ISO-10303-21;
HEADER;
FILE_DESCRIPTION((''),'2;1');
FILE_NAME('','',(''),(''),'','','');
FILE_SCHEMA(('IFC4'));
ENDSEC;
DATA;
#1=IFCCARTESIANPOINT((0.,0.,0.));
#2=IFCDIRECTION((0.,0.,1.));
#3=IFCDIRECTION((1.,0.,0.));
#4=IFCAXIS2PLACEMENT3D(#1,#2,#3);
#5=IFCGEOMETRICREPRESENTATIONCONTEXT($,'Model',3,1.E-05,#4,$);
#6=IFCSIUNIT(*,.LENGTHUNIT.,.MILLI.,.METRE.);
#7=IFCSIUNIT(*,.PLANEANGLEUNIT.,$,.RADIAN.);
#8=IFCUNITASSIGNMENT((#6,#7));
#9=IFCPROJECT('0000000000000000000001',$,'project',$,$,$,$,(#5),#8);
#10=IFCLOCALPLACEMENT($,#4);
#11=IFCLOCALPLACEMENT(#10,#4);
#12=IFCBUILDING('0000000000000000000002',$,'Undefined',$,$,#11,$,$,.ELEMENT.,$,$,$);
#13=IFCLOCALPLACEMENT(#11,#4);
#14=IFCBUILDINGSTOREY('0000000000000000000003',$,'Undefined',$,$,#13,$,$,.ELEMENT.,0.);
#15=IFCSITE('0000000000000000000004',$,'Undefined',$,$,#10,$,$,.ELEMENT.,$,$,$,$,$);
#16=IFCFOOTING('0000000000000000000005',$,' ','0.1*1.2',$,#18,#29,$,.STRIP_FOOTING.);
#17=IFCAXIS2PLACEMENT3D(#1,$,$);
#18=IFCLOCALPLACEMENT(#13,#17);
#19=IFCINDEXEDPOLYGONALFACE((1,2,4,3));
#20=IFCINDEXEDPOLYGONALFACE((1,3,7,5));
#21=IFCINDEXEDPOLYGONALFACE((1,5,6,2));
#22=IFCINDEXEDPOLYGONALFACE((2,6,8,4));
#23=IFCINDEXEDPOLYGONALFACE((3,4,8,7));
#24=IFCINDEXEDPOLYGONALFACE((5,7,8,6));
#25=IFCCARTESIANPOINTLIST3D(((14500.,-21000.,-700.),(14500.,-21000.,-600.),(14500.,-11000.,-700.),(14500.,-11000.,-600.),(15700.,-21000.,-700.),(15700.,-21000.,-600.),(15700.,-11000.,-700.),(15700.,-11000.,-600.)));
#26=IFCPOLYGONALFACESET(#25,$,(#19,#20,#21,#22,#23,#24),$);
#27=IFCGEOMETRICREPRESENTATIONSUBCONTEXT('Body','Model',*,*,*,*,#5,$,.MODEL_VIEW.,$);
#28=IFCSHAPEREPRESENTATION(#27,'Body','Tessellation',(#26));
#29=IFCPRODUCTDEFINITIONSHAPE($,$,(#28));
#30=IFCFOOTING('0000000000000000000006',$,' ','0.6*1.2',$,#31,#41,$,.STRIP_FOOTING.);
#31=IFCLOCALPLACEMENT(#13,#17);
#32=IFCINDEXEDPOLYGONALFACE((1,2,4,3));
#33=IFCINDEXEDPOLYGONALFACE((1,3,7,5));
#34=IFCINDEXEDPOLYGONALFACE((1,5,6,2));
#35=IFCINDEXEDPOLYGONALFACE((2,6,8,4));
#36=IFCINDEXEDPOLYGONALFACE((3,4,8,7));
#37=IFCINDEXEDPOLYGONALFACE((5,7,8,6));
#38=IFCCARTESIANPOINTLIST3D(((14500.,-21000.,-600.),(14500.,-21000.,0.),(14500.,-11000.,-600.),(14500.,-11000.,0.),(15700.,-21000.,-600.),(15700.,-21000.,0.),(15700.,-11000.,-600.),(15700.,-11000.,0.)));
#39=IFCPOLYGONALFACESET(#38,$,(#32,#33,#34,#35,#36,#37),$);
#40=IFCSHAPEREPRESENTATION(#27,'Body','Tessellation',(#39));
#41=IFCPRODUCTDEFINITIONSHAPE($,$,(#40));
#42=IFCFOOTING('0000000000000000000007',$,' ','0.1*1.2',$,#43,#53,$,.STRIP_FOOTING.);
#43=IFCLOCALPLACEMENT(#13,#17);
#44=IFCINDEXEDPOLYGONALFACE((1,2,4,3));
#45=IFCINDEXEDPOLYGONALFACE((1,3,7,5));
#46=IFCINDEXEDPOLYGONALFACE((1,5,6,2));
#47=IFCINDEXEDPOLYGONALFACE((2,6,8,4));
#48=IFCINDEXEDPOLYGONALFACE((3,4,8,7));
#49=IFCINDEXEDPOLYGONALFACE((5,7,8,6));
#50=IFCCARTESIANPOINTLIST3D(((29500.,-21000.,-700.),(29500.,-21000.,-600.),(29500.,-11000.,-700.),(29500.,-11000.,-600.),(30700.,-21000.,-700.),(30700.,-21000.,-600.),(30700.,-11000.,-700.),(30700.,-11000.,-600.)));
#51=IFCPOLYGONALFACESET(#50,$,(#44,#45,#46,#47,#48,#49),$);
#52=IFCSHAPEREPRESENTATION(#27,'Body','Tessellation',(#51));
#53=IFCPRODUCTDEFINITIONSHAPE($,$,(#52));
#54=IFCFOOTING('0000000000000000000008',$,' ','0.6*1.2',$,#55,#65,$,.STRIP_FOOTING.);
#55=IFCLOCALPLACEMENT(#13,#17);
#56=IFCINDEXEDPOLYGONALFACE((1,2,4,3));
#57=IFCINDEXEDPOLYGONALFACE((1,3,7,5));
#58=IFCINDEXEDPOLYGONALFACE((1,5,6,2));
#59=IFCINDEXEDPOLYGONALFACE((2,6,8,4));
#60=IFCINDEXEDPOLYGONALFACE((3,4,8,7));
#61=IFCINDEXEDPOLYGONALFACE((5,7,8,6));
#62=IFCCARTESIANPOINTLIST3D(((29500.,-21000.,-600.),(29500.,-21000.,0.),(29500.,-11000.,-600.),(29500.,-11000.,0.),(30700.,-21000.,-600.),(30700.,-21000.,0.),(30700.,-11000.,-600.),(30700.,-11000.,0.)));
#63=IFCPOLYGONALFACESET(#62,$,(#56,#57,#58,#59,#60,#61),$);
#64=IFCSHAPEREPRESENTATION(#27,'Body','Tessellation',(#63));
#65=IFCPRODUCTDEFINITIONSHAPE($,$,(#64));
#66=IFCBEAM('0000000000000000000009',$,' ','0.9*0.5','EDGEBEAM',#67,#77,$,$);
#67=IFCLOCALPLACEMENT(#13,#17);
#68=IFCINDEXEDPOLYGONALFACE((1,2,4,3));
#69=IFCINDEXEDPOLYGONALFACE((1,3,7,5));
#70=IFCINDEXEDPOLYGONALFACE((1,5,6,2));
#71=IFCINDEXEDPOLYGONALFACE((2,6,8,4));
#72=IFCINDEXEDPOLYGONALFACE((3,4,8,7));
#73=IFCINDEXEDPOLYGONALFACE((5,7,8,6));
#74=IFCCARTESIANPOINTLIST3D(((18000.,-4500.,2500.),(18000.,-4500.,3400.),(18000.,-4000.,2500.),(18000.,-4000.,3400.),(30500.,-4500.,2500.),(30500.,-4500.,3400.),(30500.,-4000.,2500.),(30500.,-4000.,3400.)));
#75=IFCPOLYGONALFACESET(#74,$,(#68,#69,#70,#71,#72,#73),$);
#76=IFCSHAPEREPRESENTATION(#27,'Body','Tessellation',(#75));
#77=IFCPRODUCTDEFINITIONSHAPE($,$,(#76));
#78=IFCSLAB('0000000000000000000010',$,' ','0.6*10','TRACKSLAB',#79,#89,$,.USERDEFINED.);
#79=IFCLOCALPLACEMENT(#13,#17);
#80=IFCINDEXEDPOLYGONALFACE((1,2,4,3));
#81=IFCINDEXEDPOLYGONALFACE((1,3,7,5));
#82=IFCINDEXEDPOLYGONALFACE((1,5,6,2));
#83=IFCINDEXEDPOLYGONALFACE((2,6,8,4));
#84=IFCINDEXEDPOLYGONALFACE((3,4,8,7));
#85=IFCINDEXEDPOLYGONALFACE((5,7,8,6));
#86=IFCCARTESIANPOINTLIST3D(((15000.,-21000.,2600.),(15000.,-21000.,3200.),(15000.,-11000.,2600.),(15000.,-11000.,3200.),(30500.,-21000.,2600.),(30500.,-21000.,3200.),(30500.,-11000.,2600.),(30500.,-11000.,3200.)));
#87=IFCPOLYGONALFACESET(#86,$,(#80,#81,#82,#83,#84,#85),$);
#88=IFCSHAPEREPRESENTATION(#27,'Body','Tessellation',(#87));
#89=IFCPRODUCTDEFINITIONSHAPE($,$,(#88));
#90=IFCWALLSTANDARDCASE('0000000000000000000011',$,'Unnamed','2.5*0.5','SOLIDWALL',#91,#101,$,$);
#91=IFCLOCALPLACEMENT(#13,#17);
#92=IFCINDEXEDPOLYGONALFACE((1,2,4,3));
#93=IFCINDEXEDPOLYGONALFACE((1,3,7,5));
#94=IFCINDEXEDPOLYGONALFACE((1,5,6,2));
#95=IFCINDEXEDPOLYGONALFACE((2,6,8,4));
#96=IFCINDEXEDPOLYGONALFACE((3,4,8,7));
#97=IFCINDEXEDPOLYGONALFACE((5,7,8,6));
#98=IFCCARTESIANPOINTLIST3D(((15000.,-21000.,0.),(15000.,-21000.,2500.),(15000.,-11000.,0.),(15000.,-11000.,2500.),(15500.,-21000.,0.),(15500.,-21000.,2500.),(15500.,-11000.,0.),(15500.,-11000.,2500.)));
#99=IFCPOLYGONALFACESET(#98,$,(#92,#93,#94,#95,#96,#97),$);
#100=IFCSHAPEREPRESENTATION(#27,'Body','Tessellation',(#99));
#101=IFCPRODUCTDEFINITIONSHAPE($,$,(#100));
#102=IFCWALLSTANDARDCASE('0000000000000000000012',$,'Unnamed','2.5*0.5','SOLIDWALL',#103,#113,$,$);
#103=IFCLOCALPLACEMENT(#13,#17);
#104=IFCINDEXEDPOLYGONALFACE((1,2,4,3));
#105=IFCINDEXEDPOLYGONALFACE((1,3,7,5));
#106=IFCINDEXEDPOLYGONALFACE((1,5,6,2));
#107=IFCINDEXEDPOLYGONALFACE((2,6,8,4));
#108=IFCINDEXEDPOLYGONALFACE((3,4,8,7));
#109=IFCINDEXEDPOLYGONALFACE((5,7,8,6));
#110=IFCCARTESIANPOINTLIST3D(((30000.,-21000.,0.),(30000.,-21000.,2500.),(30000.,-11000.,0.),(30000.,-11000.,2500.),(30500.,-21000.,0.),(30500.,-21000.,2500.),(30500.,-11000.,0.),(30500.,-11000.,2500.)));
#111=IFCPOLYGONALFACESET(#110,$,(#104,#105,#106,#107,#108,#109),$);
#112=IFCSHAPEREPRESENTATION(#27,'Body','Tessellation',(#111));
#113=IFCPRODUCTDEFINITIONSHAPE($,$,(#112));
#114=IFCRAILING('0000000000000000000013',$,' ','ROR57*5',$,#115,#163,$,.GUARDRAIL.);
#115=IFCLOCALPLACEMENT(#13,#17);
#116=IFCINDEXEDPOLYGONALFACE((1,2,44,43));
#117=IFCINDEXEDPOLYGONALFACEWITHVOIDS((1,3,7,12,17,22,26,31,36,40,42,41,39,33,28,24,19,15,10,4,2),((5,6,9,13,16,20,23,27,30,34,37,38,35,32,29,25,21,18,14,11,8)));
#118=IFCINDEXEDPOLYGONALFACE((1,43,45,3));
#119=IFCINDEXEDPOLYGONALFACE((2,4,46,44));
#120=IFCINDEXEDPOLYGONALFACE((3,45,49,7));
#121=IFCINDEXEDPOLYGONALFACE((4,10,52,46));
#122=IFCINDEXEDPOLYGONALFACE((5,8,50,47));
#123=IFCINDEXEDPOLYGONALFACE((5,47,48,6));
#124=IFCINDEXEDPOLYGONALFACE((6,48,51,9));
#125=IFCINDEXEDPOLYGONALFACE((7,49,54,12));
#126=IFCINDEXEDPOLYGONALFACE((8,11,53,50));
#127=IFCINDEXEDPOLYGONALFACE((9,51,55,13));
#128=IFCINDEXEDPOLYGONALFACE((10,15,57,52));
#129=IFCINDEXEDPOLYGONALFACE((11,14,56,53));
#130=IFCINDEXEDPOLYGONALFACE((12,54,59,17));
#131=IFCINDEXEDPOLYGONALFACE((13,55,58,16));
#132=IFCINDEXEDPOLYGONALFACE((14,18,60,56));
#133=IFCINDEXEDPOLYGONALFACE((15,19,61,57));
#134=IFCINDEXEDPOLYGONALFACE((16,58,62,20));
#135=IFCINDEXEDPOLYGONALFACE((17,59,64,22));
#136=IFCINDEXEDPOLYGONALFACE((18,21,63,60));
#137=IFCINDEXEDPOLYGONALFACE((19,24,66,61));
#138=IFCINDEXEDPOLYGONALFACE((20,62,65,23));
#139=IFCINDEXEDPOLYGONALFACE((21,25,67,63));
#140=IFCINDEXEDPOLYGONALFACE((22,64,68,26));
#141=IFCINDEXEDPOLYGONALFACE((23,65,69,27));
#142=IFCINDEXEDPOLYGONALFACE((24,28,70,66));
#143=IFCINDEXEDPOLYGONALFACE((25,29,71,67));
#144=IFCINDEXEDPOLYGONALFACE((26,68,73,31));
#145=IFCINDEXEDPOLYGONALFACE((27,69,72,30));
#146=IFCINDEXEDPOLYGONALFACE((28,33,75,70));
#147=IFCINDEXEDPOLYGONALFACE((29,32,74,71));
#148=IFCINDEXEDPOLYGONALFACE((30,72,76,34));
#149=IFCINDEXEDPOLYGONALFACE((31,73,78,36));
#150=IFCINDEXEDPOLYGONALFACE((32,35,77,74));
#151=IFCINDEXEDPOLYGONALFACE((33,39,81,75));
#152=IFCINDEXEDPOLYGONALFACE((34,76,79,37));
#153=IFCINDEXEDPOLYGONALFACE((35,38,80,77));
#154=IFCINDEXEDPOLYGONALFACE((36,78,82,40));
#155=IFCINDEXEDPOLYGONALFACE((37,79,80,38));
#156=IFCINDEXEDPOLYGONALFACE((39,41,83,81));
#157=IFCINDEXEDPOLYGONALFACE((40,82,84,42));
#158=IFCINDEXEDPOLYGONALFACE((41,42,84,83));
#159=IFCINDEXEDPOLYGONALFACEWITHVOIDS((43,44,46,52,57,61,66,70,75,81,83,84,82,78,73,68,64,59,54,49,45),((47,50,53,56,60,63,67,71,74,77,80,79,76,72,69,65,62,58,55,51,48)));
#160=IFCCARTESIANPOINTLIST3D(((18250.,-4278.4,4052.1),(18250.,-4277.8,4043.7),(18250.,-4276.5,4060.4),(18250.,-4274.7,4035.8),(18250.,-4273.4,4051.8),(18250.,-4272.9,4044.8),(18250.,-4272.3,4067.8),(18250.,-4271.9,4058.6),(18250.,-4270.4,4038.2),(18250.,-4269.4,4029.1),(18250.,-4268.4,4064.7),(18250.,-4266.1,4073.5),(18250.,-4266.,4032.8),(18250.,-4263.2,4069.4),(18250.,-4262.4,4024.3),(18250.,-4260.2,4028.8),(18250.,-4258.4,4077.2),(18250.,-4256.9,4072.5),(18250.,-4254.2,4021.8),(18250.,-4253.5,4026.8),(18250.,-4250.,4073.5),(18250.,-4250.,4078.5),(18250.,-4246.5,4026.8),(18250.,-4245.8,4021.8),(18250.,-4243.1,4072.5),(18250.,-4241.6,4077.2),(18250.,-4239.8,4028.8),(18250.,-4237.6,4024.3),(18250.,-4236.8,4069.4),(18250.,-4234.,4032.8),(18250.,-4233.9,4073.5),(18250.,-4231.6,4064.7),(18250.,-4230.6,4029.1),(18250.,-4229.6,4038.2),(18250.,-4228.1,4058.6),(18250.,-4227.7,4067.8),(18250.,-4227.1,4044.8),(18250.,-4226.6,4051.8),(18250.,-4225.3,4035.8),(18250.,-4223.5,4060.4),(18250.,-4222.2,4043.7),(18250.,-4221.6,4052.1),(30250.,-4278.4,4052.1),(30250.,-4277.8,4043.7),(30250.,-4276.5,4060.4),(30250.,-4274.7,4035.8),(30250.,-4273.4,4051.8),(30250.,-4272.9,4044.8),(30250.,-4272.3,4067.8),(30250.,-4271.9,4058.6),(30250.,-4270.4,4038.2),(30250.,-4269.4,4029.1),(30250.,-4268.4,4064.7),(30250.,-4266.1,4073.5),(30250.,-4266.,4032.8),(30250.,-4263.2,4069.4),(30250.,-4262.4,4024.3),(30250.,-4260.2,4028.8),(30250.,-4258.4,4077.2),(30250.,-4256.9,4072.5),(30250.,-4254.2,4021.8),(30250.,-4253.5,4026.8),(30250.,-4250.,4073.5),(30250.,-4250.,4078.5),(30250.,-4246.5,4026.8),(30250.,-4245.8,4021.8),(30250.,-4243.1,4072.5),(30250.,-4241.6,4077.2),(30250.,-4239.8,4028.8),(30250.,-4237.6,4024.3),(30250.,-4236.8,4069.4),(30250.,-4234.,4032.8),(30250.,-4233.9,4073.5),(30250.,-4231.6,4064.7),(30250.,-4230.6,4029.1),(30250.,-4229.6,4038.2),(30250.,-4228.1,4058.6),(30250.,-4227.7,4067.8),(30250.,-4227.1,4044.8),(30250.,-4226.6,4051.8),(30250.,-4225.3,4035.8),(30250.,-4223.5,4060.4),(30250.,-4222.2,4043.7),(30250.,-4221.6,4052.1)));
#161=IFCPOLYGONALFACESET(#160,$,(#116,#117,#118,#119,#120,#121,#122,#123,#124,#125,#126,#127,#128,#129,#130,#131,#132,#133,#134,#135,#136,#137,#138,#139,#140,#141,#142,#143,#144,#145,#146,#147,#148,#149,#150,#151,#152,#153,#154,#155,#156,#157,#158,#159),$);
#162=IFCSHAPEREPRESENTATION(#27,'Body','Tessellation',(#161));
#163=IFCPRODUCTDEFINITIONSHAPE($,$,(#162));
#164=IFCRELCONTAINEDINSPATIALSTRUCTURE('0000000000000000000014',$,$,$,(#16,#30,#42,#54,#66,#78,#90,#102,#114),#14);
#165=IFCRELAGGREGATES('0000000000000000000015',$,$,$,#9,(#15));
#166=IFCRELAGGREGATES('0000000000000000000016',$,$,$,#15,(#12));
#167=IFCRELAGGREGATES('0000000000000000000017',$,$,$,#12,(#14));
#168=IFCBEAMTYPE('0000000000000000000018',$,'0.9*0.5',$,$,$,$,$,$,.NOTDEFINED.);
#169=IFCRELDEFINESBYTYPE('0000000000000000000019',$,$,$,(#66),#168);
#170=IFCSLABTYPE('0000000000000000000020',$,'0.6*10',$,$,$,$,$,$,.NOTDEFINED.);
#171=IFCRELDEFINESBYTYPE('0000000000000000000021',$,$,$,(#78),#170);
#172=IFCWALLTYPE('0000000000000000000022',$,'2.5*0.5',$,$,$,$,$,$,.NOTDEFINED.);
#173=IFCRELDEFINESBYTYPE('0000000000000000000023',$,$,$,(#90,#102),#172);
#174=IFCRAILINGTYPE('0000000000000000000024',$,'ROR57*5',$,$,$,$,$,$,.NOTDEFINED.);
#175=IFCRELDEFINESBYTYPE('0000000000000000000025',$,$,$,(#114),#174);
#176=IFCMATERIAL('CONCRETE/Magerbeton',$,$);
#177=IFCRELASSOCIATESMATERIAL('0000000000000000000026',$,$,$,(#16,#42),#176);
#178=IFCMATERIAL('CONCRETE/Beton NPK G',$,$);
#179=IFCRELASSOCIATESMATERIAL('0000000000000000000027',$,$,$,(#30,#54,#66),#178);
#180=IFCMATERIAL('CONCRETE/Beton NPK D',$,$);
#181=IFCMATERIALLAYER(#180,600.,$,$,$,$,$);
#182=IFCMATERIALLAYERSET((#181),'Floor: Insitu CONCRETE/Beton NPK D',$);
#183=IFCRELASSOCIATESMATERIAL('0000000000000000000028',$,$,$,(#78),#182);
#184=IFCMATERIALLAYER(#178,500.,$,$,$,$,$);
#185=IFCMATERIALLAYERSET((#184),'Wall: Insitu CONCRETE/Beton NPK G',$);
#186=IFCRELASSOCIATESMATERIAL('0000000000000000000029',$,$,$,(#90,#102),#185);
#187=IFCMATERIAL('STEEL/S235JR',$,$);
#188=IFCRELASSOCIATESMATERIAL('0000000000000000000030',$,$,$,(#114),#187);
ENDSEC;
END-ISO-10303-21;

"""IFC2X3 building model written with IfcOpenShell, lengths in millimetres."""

from ifc_helpers import new_model, si_unit, frame, frame_2d, origin_with_axes, origin_2d_with_axis, place, context, subcontext, project, spatial, polyline, rectangle, hollow_circle, outline, extrude, material, layer, layer_set, layer_usage, type_object, element, save


model = new_model("IFC2X3")

# Units and contexts
model_context = context("Model", 3, precision=1e-05, world=origin_with_axes())
body_context = subcontext(model_context, "Body", "Model", "MODEL_VIEW")
ifc_project = project(units=[si_unit("LENGTHUNIT", "METRE", prefix="MILLI"), si_unit("PLANEANGLEUNIT", "RADIAN")], contexts=[model_context])

# Site, building, storey
site_placement = place(None, origin_with_axes())
site = spatial("IfcSite", under=ifc_project, at=site_placement, Name="Undefined", CompositionType="ELEMENT")
building_placement = place(site_placement, origin_with_axes())
building = spatial("IfcBuilding", under=site, at=building_placement, Name="Undefined", CompositionType="ELEMENT")
storey_placement = place(building_placement, origin_with_axes())
storey = spatial("IfcBuildingStorey", under=building, at=storey_placement, Name="Undefined", CompositionType="ELEMENT", Elevation=0.0)

# Footings
ifc_material_1 = material(Name="CONCRETE/Magerbeton")
footing_1_placement = place(storey_placement, frame((15100.0, -11000.0, -650.0), z_axis=(0.0, 0.0, 1.0), x_axis=(0.0, -1.0, 0.0)))
element("IfcFooting", 1, at=footing_1_placement, inside=storey, material=ifc_material_1, Name=" ", Description="0.1*1.2", PredefinedType="STRIP_FOOTING", context=body_context, shape_type="SweptSolid", body=[
    extrude(rectangle(XDim=1200.0, YDim=100.0, at=origin_2d_with_axis()), frame((10000.0, 0.0, 0.0), z_axis=(-1.0, 0.0, 0.0), x_axis=(0.0, -1.0, 0.0)), (0.0, 0.0, 1.0), 10000.0),
])
ifc_material_2 = material(Name="CONCRETE/Beton NPK G")
footing_2_placement = place(storey_placement, frame((15100.0, -11000.0, -300.0), z_axis=(0.0, 0.0, 1.0), x_axis=(0.0, -1.0, 0.0)))
element("IfcFooting", 2, at=footing_2_placement, inside=storey, material=ifc_material_2, Name=" ", Description="0.6*1.2", PredefinedType="STRIP_FOOTING", context=body_context, shape_type="SweptSolid", body=[
    extrude(rectangle(XDim=1200.0, YDim=600.0, at=origin_2d_with_axis()), frame((10000.0, 0.0, 0.0), z_axis=(-1.0, 0.0, 0.0), x_axis=(0.0, -1.0, 0.0)), (0.0, 0.0, 1.0), 10000.0),
])
footing_3_placement = place(storey_placement, frame((30100.0, -11000.0, -650.0), z_axis=(0.0, 0.0, 1.0), x_axis=(0.0, -1.0, 0.0)))
element("IfcFooting", 3, at=footing_3_placement, inside=storey, material=ifc_material_1, Name=" ", Description="0.1*1.2", PredefinedType="STRIP_FOOTING", context=body_context, shape_type="SweptSolid", body=[
    extrude(rectangle(XDim=1200.0, YDim=100.0, at=origin_2d_with_axis()), frame((10000.0, 0.0, 0.0), z_axis=(-1.0, 0.0, 0.0), x_axis=(0.0, -1.0, 0.0)), (0.0, 0.0, 1.0), 10000.0),
])
footing_4_placement = place(storey_placement, frame((30100.0, -11000.0, -300.0), z_axis=(0.0, 0.0, 1.0), x_axis=(0.0, -1.0, 0.0)))
element("IfcFooting", 4, at=footing_4_placement, inside=storey, material=ifc_material_2, Name=" ", Description="0.6*1.2", PredefinedType="STRIP_FOOTING", context=body_context, shape_type="SweptSolid", body=[
    extrude(rectangle(XDim=1200.0, YDim=600.0, at=origin_2d_with_axis()), frame((10000.0, 0.0, 0.0), z_axis=(-1.0, 0.0, 0.0), x_axis=(0.0, -1.0, 0.0)), (0.0, 0.0, 1.0), 10000.0),
])

# Beam
beam_type = type_object("IfcBeamType", Name="0.9*0.5", PredefinedType="NOTDEFINED")
beam_placement = place(storey_placement, frame((30500.0, -4250.0, 2950.0), z_axis=(0.0, 0.0, 1.0), x_axis=(-1.0, 0.0, 0.0)))
element("IfcBeam", 5, at=beam_placement, inside=storey, type_object=beam_type, material=ifc_material_2, Name=" ", Description="0.9*0.5", ObjectType="EDGEBEAM", context=body_context, shape_type="SweptSolid", body=[
    extrude(rectangle(XDim=500.0, YDim=900.0, at=origin_2d_with_axis()), frame((12500.0, 0.0, 0.0), z_axis=(-1.0, 0.0, 0.0), x_axis=(0.0, -1.0, 0.0)), (0.0, 0.0, 1.0), 12500.0),
])

# Slab
ifc_material_3 = material(Name="CONCRETE/Beton NPK D")
ifc_layer_1 = layer(ifc_material_3, 600.0)
ifc_layer_set_1 = layer_set([ifc_layer_1], Name="Floor: Insitu CONCRETE/Beton NPK D")
ifc_layer_usage_1 = layer_usage(ifc_layer_set_1, "AXIS3", "POSITIVE", -300.0)
slab_type = type_object("IfcSlabType", Name="0.6*10", PredefinedType="NOTDEFINED")
slab_placement = place(storey_placement, frame((30500.0, -11000.0, 2900.0), z_axis=(0.0, 0.0, 1.0), x_axis=(-1.0, 0.0, 0.0)))
element("IfcSlab", 6, at=slab_placement, inside=storey, type_object=slab_type, material=ifc_layer_usage_1, Name=" ", Description="0.6*10", ObjectType="TRACKSLAB", PredefinedType="USERDEFINED", context=body_context, shape_type="SweptSolid", body=[
    extrude(outline(polyline([(0.0, 0.0), (15500.0, 0.0), (15500.0, 10000.0), (0.0, 10000.0), (0.0, 0.0)])), frame((0.0, 0.0, -300.0), z_axis=(0.0, 0.0, 1.0), x_axis=(1.0, 0.0, 0.0)), (0.0, 0.0, 1.0), 600.0),
])

# Walls
ifc_layer_2 = layer(ifc_material_2, 500.0)
ifc_layer_set_2 = layer_set([ifc_layer_2], Name="Wall: Insitu CONCRETE/Beton NPK G")
ifc_layer_usage_2 = layer_usage(ifc_layer_set_2, "AXIS2", "POSITIVE", -250.0)
wall_type = type_object("IfcWallType", Name="2.5*0.5", PredefinedType="NOTDEFINED")
wall_1_placement = place(storey_placement, frame((15250.0, -21000.0, 0.0), z_axis=(0.0, 0.0, 1.0), x_axis=(0.0, 1.0, 0.0)))
element("IfcWallStandardCase", 7, at=wall_1_placement, inside=storey, type_object=wall_type, material=ifc_layer_usage_2, Name="Unnamed", Description="2.5*0.5", ObjectType="SOLIDWALL", context=body_context, shape_type="SweptSolid", body=[
    extrude(rectangle(XDim=10000.0, YDim=500.0, at=frame_2d((0.0, 5000.0), x_axis=(0.0, -1.0))), frame((0.0, 0.0, 0.0), z_axis=(0.0, 0.0, 1.0), x_axis=(0.0, -1.0, 0.0)), (0.0, 0.0, 1.0), 2500.0),
])
ifc_layer_usage_3 = layer_usage(ifc_layer_set_2, "AXIS2", "POSITIVE", -250.0)
wall_2_placement = place(storey_placement, frame((30250.0, -21000.0, 0.0), z_axis=(0.0, 0.0, 1.0), x_axis=(0.0, 1.0, 0.0)))
element("IfcWallStandardCase", 8, at=wall_2_placement, inside=storey, type_object=wall_type, material=ifc_layer_usage_3, Name="Unnamed", Description="2.5*0.5", ObjectType="SOLIDWALL", context=body_context, shape_type="SweptSolid", body=[
    extrude(rectangle(XDim=10000.0, YDim=500.0, at=frame_2d((0.0, 5000.0), x_axis=(0.0, -1.0))), frame((0.0, 0.0, 0.0), z_axis=(0.0, 0.0, 1.0), x_axis=(0.0, -1.0, 0.0)), (0.0, 0.0, 1.0), 2500.0),
])

# Railing
ifc_material_4 = material(Name="STEEL/S235JR")
railing_type = type_object("IfcRailingType", Name="ROR57*5", PredefinedType="NOTDEFINED")
railing_1_placement = place(storey_placement, frame((30250.0, -4250.0, 4050.0), z_axis=(0.0, -1.0, 0.0), x_axis=(-1.0, 0.0, 0.0)))
element("IfcRailing", 9, at=railing_1_placement, inside=storey, type_object=railing_type, material=ifc_material_4, Name=" ", Description="ROR57*5", PredefinedType="GUARDRAIL", context=body_context, shape_type="SweptSolid", body=[
    extrude(hollow_circle(Radius=28.5, WallThickness=5.0, at=origin_2d_with_axis()), frame((12000.0, 0.0, 0.0), z_axis=(-1.0, 0.0, 0.0), x_axis=(0.0, -1.0, 0.0)), (0.0, 0.0, 1.0), 12000.0),
])

save(model, "model.ifc")
